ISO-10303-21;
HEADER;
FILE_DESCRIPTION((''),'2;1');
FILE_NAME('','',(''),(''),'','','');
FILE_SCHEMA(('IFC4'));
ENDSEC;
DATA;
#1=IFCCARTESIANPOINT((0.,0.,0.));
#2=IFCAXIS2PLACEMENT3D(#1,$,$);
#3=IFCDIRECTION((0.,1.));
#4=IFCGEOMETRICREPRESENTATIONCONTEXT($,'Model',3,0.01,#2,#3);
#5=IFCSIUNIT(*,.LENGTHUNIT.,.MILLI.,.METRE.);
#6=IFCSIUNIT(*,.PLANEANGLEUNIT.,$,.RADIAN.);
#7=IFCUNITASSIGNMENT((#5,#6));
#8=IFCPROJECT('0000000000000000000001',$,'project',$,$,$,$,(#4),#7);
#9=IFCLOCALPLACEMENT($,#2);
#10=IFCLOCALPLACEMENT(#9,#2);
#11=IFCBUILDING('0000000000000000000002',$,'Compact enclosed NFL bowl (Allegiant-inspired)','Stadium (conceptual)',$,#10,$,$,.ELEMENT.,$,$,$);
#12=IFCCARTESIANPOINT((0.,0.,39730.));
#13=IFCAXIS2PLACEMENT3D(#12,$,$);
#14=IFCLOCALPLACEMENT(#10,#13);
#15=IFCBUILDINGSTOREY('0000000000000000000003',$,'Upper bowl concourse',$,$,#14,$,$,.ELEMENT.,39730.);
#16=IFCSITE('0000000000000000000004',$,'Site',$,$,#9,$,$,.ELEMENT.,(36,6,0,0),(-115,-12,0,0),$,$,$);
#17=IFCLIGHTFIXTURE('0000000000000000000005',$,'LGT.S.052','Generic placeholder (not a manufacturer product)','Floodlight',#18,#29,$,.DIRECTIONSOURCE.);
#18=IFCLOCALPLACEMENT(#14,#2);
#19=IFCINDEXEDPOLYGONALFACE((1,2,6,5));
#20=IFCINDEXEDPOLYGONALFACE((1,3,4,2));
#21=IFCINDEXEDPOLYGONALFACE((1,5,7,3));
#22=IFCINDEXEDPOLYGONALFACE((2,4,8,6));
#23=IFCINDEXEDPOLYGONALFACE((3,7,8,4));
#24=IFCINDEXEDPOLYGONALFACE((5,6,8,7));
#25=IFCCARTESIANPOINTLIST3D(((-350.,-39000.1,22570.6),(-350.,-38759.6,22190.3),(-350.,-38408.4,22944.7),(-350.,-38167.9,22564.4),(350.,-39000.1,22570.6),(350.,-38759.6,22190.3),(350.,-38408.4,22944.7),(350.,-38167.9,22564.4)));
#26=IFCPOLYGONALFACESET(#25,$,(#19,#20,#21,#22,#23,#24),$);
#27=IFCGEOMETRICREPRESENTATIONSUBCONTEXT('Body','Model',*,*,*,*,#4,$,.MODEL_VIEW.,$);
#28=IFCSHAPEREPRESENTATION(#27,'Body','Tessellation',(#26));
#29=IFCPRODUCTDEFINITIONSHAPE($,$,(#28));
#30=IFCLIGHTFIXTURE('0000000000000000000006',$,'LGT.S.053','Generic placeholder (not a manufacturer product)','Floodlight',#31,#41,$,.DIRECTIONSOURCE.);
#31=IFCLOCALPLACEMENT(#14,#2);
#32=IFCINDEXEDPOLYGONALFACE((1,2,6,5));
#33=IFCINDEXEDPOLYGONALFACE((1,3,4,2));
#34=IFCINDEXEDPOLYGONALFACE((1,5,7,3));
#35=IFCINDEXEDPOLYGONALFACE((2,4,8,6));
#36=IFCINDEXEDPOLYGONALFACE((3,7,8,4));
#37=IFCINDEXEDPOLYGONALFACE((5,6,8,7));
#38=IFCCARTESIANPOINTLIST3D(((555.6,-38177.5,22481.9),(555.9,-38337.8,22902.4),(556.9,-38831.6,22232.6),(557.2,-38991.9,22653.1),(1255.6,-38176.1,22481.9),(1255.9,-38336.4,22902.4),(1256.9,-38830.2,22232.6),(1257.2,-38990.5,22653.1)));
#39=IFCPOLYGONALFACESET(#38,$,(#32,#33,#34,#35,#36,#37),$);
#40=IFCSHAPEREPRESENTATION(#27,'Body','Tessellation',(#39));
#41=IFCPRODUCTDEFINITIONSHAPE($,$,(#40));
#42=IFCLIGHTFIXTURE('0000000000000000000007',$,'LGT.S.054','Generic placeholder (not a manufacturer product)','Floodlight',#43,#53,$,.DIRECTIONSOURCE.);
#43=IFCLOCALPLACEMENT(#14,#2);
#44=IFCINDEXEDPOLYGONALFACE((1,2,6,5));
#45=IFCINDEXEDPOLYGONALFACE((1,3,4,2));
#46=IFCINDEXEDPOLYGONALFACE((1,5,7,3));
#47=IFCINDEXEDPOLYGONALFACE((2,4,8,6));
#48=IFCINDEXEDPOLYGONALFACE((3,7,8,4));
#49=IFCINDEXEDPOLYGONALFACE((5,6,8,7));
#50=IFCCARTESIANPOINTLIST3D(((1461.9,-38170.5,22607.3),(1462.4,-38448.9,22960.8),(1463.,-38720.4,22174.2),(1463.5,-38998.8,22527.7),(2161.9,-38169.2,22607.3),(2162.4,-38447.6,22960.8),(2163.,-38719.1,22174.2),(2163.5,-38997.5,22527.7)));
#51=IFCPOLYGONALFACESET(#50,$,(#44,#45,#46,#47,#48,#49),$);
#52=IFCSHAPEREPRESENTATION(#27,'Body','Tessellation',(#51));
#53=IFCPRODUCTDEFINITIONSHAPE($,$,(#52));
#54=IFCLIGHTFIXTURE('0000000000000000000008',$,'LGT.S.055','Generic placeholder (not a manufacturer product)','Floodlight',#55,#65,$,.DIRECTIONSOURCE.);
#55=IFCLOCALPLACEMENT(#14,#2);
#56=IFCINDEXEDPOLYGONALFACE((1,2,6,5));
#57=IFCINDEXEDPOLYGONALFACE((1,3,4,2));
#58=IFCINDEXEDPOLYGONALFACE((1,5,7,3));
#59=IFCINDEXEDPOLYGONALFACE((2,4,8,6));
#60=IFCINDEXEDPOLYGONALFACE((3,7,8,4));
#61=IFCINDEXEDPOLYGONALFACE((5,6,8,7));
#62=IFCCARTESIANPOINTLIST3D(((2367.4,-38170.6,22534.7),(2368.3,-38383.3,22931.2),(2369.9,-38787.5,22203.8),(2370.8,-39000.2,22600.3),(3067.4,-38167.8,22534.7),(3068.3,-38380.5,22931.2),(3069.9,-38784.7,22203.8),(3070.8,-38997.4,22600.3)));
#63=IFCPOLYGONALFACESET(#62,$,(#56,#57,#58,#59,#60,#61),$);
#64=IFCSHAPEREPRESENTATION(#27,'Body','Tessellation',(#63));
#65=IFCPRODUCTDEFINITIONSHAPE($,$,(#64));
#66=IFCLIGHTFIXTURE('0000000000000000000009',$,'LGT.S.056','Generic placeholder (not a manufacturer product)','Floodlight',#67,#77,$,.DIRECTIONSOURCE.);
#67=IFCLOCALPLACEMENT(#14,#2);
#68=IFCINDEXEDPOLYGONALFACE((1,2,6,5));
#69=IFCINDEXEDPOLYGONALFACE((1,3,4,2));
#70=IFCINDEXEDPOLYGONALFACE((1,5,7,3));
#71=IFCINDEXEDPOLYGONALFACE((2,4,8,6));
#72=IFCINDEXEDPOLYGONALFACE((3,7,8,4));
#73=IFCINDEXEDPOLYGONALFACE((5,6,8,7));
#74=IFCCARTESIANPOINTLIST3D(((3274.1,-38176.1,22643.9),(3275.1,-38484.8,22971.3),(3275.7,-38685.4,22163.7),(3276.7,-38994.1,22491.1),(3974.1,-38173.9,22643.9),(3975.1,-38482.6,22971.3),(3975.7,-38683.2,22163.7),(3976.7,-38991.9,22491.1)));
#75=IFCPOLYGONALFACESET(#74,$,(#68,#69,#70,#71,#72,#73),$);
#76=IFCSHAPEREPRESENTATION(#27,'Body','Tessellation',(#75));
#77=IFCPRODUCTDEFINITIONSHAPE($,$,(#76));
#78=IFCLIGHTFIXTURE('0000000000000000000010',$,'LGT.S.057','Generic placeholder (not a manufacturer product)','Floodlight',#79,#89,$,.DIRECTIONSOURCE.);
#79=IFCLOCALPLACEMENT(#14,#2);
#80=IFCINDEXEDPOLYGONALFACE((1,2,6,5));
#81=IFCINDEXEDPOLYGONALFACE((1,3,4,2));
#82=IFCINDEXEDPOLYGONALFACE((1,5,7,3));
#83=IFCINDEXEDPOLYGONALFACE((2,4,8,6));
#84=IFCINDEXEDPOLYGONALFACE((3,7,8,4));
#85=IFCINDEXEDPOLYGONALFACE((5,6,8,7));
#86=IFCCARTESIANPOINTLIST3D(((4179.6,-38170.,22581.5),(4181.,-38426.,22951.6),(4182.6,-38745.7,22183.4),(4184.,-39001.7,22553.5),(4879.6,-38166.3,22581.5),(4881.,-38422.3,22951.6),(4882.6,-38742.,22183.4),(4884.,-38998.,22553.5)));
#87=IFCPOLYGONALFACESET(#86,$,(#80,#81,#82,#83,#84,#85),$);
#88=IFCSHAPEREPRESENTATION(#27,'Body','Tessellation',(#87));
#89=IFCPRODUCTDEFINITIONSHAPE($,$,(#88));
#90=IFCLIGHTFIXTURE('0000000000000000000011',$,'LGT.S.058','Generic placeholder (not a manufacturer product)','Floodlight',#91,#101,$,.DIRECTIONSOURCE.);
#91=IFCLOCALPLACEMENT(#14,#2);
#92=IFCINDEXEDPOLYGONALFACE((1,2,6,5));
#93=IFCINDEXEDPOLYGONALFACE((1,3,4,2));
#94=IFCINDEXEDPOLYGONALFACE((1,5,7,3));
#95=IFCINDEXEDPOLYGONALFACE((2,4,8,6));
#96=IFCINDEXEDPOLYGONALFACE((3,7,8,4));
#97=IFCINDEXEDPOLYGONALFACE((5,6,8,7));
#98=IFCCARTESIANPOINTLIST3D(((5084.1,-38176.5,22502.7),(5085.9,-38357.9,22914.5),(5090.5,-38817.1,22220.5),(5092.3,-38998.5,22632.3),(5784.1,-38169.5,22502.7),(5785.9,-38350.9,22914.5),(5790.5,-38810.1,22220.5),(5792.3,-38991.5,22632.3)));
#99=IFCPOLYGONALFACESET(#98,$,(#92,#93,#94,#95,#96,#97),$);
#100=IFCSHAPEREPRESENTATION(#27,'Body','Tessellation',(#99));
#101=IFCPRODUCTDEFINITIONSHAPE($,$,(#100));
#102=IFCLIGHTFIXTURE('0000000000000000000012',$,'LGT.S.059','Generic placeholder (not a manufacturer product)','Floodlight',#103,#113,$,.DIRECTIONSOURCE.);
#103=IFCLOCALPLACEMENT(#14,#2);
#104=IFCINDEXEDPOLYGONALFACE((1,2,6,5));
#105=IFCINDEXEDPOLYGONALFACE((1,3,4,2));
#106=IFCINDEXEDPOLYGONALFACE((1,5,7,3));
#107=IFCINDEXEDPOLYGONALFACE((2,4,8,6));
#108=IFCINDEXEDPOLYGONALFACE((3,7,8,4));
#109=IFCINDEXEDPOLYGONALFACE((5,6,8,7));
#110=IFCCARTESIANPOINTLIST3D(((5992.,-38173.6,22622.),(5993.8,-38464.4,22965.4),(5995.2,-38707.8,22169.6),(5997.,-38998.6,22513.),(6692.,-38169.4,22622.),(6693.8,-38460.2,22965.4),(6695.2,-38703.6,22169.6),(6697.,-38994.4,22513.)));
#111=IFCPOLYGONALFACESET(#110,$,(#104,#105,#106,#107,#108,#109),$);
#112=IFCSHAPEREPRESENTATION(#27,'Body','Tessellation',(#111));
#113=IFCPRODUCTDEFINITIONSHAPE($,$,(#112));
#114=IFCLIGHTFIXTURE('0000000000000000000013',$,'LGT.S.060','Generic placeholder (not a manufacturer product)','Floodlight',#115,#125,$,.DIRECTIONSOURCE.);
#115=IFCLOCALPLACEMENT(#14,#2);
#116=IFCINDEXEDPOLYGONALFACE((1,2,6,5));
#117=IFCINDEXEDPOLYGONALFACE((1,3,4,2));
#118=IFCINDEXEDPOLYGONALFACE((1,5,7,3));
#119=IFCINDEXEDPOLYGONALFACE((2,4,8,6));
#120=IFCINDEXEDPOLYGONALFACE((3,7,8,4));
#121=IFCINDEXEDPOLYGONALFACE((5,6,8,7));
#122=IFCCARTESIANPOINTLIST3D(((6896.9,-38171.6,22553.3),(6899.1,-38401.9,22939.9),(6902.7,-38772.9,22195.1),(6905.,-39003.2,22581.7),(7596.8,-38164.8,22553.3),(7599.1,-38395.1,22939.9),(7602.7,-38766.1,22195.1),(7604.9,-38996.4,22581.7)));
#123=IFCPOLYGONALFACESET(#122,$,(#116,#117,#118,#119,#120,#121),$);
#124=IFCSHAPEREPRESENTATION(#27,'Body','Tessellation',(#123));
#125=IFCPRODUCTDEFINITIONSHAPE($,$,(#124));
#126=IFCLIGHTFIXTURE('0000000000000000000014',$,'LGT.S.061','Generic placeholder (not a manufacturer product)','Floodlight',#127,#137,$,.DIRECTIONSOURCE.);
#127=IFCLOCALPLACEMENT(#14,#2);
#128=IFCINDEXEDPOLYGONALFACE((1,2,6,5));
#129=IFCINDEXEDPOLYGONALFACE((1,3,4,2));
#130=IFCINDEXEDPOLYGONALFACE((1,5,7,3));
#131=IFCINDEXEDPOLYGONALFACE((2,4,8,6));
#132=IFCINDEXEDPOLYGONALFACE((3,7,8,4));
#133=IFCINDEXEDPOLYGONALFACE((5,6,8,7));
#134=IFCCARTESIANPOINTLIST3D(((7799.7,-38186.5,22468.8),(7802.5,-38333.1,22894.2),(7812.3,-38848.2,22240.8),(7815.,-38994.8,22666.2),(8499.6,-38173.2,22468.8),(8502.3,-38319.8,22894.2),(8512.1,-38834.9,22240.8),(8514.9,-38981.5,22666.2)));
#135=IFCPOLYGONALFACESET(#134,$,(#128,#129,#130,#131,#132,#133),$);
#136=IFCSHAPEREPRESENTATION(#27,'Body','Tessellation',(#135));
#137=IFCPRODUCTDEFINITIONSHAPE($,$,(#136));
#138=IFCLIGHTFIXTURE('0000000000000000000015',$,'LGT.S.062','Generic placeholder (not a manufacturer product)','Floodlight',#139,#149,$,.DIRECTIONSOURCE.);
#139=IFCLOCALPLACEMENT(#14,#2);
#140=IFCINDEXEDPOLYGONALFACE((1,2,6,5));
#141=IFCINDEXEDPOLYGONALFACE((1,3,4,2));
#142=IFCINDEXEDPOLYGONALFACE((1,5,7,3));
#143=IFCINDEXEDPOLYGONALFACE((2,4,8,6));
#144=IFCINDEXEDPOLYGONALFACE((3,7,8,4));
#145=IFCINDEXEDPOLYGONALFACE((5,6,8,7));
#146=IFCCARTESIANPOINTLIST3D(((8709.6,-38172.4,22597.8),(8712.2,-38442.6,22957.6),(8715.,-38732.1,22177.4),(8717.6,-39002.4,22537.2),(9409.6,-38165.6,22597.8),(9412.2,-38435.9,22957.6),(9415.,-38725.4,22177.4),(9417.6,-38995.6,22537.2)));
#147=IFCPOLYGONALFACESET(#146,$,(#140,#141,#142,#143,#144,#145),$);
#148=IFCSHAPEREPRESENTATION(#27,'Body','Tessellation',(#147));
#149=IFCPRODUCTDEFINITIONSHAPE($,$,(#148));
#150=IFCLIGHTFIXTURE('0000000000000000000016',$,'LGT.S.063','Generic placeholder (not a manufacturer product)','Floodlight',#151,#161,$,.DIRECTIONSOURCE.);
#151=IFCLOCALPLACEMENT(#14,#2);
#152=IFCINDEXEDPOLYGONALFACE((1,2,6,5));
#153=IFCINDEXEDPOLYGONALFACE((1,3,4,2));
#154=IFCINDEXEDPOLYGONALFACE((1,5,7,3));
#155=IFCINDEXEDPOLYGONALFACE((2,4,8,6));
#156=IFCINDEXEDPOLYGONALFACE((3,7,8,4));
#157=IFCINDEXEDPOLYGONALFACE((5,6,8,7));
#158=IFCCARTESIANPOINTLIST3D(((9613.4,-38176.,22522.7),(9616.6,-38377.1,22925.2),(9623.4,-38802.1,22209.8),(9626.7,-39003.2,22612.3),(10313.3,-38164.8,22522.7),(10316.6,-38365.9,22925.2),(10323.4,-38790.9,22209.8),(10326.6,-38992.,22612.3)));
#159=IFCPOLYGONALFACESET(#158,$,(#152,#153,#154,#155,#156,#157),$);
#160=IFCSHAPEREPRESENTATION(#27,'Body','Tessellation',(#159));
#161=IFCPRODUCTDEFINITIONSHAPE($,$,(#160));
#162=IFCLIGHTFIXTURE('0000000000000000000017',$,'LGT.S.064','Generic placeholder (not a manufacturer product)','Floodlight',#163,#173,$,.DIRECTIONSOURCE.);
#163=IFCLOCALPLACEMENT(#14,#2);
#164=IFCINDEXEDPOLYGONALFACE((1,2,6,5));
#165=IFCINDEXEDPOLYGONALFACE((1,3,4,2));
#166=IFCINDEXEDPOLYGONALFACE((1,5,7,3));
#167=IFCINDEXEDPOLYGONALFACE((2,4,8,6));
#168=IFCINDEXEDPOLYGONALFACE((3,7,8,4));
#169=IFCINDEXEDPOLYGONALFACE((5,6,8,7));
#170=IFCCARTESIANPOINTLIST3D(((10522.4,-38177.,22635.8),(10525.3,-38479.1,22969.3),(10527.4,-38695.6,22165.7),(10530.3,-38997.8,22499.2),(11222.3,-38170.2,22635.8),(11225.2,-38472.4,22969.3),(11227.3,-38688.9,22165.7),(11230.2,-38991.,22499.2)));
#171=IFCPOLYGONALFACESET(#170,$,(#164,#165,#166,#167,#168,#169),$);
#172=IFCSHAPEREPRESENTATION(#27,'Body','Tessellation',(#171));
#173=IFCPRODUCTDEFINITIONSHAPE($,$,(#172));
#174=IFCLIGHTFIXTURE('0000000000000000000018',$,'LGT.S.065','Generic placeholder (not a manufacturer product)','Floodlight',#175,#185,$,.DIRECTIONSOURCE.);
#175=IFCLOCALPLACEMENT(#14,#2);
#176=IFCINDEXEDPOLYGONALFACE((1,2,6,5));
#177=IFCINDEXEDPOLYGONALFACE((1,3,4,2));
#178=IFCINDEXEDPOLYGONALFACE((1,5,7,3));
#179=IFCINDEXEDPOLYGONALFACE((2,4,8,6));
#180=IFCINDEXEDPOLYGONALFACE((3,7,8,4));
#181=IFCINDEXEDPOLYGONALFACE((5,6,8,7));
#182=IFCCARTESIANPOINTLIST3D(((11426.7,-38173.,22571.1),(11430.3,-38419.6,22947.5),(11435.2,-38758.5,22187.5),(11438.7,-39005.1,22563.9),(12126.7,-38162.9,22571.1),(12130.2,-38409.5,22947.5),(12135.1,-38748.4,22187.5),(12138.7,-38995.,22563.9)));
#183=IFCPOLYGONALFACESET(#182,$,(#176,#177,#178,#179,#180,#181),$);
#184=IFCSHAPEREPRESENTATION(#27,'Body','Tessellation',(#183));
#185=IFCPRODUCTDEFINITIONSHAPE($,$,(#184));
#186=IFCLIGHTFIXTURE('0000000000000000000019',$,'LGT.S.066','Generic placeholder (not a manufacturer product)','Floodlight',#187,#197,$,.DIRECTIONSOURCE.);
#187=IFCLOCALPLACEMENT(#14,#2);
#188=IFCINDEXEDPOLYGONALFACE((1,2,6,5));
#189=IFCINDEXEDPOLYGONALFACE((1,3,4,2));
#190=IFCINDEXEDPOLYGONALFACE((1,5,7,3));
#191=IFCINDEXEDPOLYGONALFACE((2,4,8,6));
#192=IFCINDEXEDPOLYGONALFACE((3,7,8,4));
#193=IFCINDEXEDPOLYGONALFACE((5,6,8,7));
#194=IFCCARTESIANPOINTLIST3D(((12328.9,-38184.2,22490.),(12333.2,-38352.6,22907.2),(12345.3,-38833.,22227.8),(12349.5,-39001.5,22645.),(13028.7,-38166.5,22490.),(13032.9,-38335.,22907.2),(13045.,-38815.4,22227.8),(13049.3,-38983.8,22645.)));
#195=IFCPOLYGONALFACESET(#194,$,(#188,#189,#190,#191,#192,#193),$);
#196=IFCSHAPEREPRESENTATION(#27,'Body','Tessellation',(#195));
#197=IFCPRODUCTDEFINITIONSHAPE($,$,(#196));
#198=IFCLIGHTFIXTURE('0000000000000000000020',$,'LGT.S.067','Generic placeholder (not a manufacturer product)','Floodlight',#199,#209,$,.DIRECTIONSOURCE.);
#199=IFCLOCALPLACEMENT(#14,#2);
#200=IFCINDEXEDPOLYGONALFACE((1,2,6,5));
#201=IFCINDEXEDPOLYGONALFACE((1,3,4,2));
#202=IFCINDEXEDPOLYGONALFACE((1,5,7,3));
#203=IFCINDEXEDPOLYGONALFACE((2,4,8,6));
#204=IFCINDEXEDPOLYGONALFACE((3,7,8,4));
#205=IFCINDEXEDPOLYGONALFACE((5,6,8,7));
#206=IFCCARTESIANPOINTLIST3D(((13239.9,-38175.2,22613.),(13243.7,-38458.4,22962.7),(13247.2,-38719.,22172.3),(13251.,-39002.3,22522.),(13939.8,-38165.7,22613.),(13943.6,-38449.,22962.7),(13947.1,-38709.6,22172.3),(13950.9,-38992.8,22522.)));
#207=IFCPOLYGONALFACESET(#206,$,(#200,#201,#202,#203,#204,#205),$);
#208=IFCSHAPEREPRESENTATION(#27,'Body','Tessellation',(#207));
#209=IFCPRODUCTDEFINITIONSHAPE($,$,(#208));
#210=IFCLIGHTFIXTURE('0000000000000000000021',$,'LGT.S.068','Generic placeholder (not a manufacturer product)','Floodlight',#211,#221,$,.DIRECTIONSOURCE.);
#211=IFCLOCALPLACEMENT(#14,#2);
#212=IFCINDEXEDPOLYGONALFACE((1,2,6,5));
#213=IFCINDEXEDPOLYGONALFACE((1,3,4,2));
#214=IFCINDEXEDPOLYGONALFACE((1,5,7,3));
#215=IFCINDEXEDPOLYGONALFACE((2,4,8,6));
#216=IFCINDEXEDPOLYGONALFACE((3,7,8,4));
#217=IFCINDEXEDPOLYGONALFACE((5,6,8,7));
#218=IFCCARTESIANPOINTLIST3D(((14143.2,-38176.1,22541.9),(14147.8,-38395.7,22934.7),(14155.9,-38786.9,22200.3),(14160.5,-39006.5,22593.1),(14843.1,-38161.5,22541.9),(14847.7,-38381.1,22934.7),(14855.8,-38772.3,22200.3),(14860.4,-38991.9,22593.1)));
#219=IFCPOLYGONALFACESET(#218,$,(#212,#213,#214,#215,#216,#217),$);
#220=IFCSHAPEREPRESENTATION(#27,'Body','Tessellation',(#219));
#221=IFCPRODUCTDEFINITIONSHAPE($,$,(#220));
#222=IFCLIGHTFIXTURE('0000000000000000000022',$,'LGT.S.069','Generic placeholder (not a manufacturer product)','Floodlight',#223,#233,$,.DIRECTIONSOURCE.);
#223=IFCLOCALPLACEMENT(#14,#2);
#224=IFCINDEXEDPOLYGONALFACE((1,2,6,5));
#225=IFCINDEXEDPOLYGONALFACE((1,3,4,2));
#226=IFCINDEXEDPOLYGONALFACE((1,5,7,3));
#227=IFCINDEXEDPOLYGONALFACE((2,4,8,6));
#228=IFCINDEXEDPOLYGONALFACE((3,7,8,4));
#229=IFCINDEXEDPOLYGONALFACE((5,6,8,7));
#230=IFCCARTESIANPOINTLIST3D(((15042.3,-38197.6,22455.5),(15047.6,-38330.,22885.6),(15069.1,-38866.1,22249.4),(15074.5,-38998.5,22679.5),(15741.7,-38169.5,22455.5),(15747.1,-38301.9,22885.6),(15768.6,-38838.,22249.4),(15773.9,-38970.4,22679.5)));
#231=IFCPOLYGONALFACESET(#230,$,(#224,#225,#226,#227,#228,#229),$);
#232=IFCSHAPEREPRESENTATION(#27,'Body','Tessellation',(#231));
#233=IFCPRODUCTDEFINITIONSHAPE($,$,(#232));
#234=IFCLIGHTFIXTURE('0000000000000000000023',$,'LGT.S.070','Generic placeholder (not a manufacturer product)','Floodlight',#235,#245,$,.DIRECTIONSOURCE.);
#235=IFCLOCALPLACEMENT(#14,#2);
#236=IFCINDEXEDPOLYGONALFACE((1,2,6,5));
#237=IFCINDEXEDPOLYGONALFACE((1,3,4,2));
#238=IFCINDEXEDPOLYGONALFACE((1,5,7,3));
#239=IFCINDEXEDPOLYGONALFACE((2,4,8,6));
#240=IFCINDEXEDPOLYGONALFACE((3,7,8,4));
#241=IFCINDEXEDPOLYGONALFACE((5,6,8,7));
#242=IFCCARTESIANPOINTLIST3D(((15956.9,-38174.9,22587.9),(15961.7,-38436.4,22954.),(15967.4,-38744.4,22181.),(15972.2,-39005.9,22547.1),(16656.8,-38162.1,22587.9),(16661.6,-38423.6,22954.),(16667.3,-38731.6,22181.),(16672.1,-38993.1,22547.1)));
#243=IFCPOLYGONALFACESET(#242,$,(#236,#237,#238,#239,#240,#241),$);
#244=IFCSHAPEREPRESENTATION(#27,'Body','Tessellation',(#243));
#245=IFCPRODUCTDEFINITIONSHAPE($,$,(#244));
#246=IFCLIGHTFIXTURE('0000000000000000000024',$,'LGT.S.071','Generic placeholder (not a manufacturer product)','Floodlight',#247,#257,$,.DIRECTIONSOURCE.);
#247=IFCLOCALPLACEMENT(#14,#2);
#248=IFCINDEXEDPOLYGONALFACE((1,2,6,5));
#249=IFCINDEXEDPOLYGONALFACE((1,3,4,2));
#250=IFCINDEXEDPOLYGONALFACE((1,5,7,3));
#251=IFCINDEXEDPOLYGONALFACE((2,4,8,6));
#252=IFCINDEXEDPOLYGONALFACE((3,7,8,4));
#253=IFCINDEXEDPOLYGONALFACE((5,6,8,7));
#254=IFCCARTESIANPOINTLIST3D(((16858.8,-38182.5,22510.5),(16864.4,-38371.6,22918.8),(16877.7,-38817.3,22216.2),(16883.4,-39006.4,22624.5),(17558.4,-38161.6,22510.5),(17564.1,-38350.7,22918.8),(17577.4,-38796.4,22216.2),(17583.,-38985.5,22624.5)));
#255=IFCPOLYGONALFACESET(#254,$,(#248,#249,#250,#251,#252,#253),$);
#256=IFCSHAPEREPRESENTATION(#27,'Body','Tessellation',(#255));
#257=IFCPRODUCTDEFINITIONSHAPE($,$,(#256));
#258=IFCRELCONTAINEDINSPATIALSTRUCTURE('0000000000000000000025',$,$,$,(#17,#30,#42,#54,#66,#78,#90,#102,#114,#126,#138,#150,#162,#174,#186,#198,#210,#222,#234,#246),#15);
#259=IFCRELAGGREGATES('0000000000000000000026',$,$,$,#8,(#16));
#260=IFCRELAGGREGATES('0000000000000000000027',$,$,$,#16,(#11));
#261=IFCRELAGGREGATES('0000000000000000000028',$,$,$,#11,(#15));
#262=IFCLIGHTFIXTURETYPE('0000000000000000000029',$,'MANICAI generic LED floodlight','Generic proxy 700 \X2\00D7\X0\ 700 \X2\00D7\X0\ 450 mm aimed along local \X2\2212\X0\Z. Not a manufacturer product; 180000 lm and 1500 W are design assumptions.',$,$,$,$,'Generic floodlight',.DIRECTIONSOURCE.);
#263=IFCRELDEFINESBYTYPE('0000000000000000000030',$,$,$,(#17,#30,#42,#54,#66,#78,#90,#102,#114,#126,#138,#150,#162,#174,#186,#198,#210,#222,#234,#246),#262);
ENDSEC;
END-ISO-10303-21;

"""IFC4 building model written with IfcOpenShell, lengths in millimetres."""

from ifc_helpers import new_model, si_unit, direction, frame, origin, place, context, subcontext, project, spatial, rectangle, extrude, source, transform, mapped, type_object, type_shapes, element, save


model = new_model("IFC4")

# Units and contexts
model_context = context("Model", 3, precision=0.01, world=origin(), true_north=direction((0.0, 1.0)))
body_context = subcontext(model_context, "Body", "Model", "MODEL_VIEW")
ifc_project = project(units=[si_unit("LENGTHUNIT", "METRE", prefix="MILLI"), si_unit("PLANEANGLEUNIT", "RADIAN")], contexts=[model_context])

# Site, building, storey
site_placement = place(None, origin())
site = spatial("IfcSite", under=ifc_project, at=site_placement, Name="Site", CompositionType="ELEMENT", RefLatitude=(36, 6, 0, 0), RefLongitude=(-115, -12, 0, 0))
building_placement = place(site_placement, origin())
building = spatial("IfcBuilding", under=site, at=building_placement, Name="Compact enclosed NFL bowl (Allegiant-inspired)", Description="Stadium (conceptual)", CompositionType="ELEMENT")
storey_placement = place(building_placement, frame((0.0, 0.0, 39730.0)))
storey = spatial("IfcBuildingStorey", under=building, at=storey_placement, Name="Upper bowl concourse", CompositionType="ELEMENT", Elevation=39730.0)

# Light fixtures
light_fixture_type = type_object("IfcLightFixtureType", Name="MANICAI generic LED floodlight", Description="Generic proxy 700 × 700 × 450 mm aimed along local −Z. Not a manufacturer product; 180000 lm and 1500 W are design assumptions.", ElementType="Generic floodlight", PredefinedType="DIRECTIONSOURCE")
shared_shape = source(origin(), body_context, "Body", "SweptSolid", [
    extrude(rectangle(XDim=700.0, YDim=700.0), frame((0.0, 0.0, -225.0)), (0.0, 0.0, 1.0), 450.0),
])
type_shapes(light_fixture_type, [shared_shape])
for number, where, z_axis, x_axis, name in (
    (1, (0.0, -38584.0, 22567.5), (0.0, -0.534445, 0.845203), (1.0, 0.0, 0.0), "LGT.S.052"),
    (2, (906.4, -38584.0, 22567.5), (0.00068, -0.356162, 0.934424), (0.999998, 0.001909, 0.0), "LGT.S.053"),
    (3, (1812.7, -38584.0, 22567.5), (0.001143, -0.618717, 0.785613), (0.999998, 0.001847, 0.0), "LGT.S.054"),
    (4, (2719.1, -38584.0, 22567.5), (0.001923, -0.472682, 0.881231), (0.999992, 0.004069, 0.0), "LGT.S.055"),
    (5, (3625.4, -38584.0, 22567.5), (0.002117, -0.685986, 0.727612), (0.999995, 0.003086, 0.0), "LGT.S.056"),
    (6, (4531.8, -38584.0, 22567.5), (0.002991, -0.568825, 0.822453), (0.999986, 0.005259, 0.0), "LGT.S.057"),
    (7, (5438.2, -38584.0, 22567.5), (0.003994, -0.40308, 0.915156), (0.999951, 0.009909, 0.0), "LGT.S.058"),
    (8, (6344.5, -38584.0, 22567.5), (0.003886, -0.646248, 0.763118), (0.999982, 0.006013, 0.0), "LGT.S.059"),
    (9, (7250.9, -38584.0, 22567.5), (0.005, -0.511759, 0.859115), (0.999952, 0.009769, 0.0), "LGT.S.060"),
    (10, (8157.3, -38584.0, 22567.5), (0.00619, -0.325717, 0.945447), (0.999819, 0.019, 0.0), "LGT.S.061"),
    (11, (9063.6, -38584.0, 22567.5), (0.005817, -0.600457, 0.799636), (0.999953, 0.009687, 0.0), "LGT.S.062"),
    (12, (9970.0, -38584.0, 22567.5), (0.007158, -0.447018, 0.894496), (0.999872, 0.01601, 0.0), "LGT.S.063"),
    (13, (10876.3, -38584.0, 22567.5), (0.006469, -0.671463, 0.74101), (0.999954, 0.009633, 0.0), "LGT.S.064"),
    (14, (11782.7, -38584.0, 22567.5), (0.007911, -0.547894, 0.836511), (0.999896, 0.014437, 0.0), "LGT.S.065"),
    (15, (12689.1, -38584.0, 22567.5), (0.009443, -0.374413, 0.927214), (0.999682, 0.025213, 0.0), "LGT.S.066"),
    (16, (13595.4, -38584.0, 22567.5), (0.008478, -0.629496, 0.776957), (0.999909, 0.013467, 0.0), "LGT.S.067"),
    (17, (14501.8, -38584.0, 22567.5), (0.010159, -0.487938, 0.872819), (0.999783, 0.020815, 0.0), "LGT.S.068"),
    (18, (15408.1, -38584.0, 22567.5), (0.011818, -0.294217, 0.955666), (0.999194, 0.040136, 0.0), "LGT.S.069"),
    (19, (16314.5, -38584.0, 22567.5), (0.010655, -0.581196, 0.813694), (0.999832, 0.018329, 0.0), "LGT.S.070"),
    (20, (17220.9, -38584.0, 22567.5), (0.012541, -0.420191, 0.907349), (0.999555, 0.029832, 0.0), "LGT.S.071"),
):
    element("IfcLightFixture", number, at=place(storey_placement, frame(where, z_axis=z_axis, x_axis=x_axis)), inside=storey, type_object=light_fixture_type, Name=name, Description="Generic placeholder (not a manufacturer product)", ObjectType="Floodlight", PredefinedType="DIRECTIONSOURCE", context=body_context, shape_type="MappedRepresentation", body=[
        mapped(shared_shape, transform((0.0, 0.0, 0.0))),
    ])

save(model, "model.ifc")
